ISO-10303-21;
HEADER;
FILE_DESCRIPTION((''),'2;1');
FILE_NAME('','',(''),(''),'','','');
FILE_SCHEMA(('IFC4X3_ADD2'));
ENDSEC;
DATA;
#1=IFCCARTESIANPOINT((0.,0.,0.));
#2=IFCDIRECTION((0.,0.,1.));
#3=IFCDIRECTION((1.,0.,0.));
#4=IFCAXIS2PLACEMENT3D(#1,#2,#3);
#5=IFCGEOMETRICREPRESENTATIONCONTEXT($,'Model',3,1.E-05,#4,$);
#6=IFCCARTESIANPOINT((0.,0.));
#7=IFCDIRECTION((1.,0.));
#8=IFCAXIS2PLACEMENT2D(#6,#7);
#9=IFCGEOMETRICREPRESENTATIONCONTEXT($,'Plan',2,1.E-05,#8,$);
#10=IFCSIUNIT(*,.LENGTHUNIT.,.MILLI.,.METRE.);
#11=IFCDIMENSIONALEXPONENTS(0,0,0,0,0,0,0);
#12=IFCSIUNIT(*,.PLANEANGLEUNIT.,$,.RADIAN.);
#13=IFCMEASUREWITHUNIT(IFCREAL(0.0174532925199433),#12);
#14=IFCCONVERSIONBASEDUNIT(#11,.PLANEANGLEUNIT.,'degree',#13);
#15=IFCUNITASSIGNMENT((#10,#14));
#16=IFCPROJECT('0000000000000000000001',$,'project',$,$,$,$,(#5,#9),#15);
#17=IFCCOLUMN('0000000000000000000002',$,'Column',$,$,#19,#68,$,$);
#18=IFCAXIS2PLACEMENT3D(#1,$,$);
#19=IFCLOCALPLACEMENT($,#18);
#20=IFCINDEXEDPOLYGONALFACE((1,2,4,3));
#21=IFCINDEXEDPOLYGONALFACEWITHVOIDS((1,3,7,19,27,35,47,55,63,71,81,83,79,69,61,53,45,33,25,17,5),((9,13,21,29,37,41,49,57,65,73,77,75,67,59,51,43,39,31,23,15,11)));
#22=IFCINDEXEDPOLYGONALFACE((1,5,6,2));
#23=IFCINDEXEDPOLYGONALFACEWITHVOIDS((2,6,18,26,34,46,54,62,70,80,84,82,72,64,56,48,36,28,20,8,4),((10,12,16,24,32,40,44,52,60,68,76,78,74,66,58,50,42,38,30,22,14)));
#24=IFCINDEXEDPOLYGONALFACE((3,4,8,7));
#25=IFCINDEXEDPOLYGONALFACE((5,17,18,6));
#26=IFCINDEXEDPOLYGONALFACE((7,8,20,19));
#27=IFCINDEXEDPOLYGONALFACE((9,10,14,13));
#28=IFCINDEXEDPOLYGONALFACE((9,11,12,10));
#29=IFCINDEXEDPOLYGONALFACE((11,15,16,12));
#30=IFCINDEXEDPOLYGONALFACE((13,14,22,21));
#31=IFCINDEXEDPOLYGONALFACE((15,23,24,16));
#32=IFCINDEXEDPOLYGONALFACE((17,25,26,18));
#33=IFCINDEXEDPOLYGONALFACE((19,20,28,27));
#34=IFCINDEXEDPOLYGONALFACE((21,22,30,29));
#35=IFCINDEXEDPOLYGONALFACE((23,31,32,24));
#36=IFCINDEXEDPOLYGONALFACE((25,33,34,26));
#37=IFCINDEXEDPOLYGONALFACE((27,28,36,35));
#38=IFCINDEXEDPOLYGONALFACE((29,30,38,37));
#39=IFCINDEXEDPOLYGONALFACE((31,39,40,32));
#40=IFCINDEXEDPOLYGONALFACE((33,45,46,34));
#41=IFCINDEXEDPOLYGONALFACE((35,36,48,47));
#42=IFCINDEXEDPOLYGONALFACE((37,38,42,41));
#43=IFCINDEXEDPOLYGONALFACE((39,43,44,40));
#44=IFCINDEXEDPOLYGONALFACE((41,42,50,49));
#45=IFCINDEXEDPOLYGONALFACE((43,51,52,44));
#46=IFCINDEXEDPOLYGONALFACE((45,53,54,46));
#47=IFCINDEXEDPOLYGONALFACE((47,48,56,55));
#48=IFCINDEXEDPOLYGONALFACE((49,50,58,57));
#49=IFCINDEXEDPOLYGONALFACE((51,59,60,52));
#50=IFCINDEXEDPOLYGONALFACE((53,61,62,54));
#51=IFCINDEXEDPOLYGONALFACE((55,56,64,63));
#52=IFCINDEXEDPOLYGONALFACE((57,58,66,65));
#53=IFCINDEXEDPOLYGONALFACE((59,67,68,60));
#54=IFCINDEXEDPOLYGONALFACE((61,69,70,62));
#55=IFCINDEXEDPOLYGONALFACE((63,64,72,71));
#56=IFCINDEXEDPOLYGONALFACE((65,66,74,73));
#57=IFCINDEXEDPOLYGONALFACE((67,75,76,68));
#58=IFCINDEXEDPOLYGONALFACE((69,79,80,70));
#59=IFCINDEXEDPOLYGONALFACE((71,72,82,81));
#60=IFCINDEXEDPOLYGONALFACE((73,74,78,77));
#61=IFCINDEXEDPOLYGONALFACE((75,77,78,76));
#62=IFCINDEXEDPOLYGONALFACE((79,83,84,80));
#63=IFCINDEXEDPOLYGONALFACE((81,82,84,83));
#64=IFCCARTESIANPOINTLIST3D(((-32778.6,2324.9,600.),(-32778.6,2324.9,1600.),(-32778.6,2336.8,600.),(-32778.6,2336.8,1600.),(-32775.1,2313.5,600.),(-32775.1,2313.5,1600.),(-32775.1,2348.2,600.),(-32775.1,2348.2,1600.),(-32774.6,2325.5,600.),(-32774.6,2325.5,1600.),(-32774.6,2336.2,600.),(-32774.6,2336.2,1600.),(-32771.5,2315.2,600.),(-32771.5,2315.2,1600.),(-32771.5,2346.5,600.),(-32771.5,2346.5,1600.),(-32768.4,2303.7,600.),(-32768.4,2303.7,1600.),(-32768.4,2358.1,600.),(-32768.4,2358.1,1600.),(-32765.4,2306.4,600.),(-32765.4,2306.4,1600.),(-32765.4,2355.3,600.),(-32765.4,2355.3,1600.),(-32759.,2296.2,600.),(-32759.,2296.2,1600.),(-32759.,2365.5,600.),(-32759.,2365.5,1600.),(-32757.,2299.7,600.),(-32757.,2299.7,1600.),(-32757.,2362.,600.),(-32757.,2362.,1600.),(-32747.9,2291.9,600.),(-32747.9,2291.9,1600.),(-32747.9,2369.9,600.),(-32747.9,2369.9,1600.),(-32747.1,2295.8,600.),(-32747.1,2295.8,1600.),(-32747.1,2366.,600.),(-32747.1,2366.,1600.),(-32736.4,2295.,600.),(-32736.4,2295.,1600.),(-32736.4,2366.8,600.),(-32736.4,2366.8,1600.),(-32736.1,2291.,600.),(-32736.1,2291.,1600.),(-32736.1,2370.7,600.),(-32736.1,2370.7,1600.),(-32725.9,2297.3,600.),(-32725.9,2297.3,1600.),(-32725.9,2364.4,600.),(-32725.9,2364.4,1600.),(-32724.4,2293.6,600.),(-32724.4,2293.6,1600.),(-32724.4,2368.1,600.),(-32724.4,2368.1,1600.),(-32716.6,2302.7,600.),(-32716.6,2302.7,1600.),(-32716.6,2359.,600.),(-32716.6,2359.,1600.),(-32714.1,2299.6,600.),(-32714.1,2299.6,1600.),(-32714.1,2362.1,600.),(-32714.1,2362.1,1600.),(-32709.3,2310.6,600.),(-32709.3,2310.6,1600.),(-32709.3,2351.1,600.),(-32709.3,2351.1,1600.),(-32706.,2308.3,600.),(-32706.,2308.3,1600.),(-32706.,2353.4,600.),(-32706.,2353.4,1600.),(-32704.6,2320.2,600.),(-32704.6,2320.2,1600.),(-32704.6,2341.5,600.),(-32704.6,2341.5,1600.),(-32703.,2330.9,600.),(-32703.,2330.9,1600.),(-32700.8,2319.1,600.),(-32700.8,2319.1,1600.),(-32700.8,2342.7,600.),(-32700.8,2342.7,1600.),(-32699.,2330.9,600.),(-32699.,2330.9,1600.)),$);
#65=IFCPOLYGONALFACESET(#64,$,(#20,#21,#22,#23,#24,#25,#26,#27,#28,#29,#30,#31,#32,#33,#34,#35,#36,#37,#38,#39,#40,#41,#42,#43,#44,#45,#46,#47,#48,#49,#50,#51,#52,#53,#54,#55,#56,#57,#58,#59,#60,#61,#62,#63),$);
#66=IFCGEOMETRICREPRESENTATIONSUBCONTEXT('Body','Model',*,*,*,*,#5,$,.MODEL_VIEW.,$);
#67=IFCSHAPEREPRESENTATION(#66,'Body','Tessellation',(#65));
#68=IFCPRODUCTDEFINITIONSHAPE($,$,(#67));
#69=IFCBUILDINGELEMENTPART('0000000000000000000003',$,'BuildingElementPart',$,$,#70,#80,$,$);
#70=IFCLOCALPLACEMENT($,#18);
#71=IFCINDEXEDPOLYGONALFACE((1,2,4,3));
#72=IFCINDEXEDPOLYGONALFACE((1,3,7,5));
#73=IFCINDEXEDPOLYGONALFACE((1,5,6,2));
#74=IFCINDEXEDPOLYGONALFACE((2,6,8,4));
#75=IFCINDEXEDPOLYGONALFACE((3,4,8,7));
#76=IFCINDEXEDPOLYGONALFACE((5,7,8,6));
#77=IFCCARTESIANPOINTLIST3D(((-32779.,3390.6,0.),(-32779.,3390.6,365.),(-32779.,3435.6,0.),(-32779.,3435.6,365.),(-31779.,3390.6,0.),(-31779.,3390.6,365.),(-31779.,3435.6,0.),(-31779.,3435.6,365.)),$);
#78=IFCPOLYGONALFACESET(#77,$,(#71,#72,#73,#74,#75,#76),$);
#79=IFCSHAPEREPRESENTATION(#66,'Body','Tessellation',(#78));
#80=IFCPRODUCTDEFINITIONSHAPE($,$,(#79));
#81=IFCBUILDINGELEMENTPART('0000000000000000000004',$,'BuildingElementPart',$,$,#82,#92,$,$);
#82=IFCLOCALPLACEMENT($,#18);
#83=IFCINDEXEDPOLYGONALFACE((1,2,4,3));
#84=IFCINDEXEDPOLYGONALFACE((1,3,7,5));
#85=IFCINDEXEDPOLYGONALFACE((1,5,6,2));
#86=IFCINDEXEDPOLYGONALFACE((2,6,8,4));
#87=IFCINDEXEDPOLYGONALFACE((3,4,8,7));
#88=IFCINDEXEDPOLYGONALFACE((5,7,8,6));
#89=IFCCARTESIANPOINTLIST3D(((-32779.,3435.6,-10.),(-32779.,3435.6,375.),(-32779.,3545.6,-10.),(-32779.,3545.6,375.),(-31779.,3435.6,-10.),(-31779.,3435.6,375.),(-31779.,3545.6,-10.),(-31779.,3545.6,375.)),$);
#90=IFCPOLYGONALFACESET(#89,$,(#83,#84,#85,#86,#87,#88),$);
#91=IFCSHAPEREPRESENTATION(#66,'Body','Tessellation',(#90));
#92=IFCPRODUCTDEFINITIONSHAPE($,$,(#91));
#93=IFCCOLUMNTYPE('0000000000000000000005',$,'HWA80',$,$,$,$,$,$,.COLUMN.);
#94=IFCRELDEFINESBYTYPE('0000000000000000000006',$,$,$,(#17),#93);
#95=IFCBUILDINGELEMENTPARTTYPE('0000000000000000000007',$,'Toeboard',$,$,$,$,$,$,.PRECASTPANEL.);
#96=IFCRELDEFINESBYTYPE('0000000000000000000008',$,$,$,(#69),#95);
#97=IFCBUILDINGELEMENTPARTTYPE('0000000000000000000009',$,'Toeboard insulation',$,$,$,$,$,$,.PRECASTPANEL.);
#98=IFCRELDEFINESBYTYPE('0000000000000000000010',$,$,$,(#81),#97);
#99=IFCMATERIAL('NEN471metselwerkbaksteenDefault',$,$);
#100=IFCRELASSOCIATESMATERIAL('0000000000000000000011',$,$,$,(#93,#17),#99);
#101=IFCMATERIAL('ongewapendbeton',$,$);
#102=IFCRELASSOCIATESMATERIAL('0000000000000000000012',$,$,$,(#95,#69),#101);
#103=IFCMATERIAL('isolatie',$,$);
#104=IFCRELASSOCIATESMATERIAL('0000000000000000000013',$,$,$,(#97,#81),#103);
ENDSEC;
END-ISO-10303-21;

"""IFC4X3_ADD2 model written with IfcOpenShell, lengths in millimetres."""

from ifc_helpers import new_model, entity, si_unit, converted_unit, frame, origin_with_axes, origin_2d_with_axis, place, context, subcontext, project, rectangle, hollow_circle, extrude, material, material_profile, profile_set, profile_usage, type_object, element, save


model = new_model("IFC4X3_ADD2")

# Units and contexts
model_context = context("Model", 3, precision=1e-05, world=origin_with_axes())
plan_context = context("Plan", 2, precision=1e-05, world=origin_2d_with_axis())
body_context = subcontext(model_context, "Body", "Model", "MODEL_VIEW")
ifc_project = project(units=[si_unit("LENGTHUNIT", "METRE", prefix="MILLI"), converted_unit("PLANEANGLEUNIT", "degree", entity("IfcReal", 0.0174532925199433), si_unit("PLANEANGLEUNIT", "RADIAN"), dimensions=[0, 0, 0, 0, 0, 0, 0])], contexts=[model_context, plan_context])

# Column
ifc_material_1 = material(Name="NEN471metselwerkbaksteenDefault")
ifc_material_profile_1 = material_profile(ifc_material_1, hollow_circle(Radius=40.0, WallThickness=4.0))
ifc_profile_set_1 = profile_set([ifc_material_profile_1])
ifc_profile_usage_1 = profile_usage(ifc_profile_set_1, cardinal=5)
column_type = type_object("IfcColumnType", Name="HWA80", PredefinedType="COLUMN", material=ifc_profile_set_1)
column_placement = place(None, frame((-32739.0, 2330.9, 600.0), z_axis=(0.0, 0.0, 1.0), x_axis=(1.0, 0.0, 0.0)))
element("IfcColumn", 1, at=column_placement, type_object=column_type, material=ifc_profile_usage_1, Name="Column", context=body_context, shape_type="SweptSolid", body=[
    extrude(hollow_circle(Radius=40.0, WallThickness=4.0), origin_with_axes(), (0.0, 0.0, 1.0), 1000.0),
])

# Building element parts
ifc_material_2 = material(Name="ongewapendbeton")
ifc_material_profile_2 = material_profile(ifc_material_2, rectangle(XDim=45.0, YDim=365.0))
ifc_profile_set_2 = profile_set([ifc_material_profile_2], Name="ongewapendbeton")
ifc_profile_usage_2 = profile_usage(ifc_profile_set_2, cardinal=5)
building_element_part_type_1 = type_object("IfcBuildingElementPartType", Name="Toeboard", PredefinedType="PRECASTPANEL", material=ifc_profile_set_2)
building_element_part_1_placement = place(None, frame((-32779.0, 3413.1, 182.5), z_axis=(1.0, 0.0, 0.0), x_axis=(0.0, 1.0, 0.0)))
element("IfcBuildingElementPart", 2, at=building_element_part_1_placement, type_object=building_element_part_type_1, material=ifc_profile_usage_2, Name="BuildingElementPart", context=body_context, shape_type="SweptSolid", body=[
    extrude(rectangle(XDim=45.0, YDim=365.0), origin_with_axes(), (0.0, 0.0, 1.0), 1000.0),
])
ifc_material_3 = material(Name="isolatie")
ifc_material_profile_3 = material_profile(ifc_material_3, rectangle(XDim=110.0, YDim=385.0))
ifc_profile_set_3 = profile_set([ifc_material_profile_3], Name="isolatieEPS")
ifc_profile_usage_3 = profile_usage(ifc_profile_set_3, cardinal=5)
building_element_part_type_2 = type_object("IfcBuildingElementPartType", Name="Toeboard insulation", PredefinedType="PRECASTPANEL", material=ifc_profile_set_3)
building_element_part_2_placement = place(None, frame((-32779.0, 3490.6, 182.5), z_axis=(1.0, 0.0, 0.0), x_axis=(0.0, 1.0, 0.0)))
element("IfcBuildingElementPart", 3, at=building_element_part_2_placement, type_object=building_element_part_type_2, material=ifc_profile_usage_3, Name="BuildingElementPart", context=body_context, shape_type="SweptSolid", body=[
    extrude(rectangle(XDim=110.0, YDim=385.0), origin_with_axes(), (0.0, 0.0, 1.0), 1000.0),
])

save(model, "model.ifc")
